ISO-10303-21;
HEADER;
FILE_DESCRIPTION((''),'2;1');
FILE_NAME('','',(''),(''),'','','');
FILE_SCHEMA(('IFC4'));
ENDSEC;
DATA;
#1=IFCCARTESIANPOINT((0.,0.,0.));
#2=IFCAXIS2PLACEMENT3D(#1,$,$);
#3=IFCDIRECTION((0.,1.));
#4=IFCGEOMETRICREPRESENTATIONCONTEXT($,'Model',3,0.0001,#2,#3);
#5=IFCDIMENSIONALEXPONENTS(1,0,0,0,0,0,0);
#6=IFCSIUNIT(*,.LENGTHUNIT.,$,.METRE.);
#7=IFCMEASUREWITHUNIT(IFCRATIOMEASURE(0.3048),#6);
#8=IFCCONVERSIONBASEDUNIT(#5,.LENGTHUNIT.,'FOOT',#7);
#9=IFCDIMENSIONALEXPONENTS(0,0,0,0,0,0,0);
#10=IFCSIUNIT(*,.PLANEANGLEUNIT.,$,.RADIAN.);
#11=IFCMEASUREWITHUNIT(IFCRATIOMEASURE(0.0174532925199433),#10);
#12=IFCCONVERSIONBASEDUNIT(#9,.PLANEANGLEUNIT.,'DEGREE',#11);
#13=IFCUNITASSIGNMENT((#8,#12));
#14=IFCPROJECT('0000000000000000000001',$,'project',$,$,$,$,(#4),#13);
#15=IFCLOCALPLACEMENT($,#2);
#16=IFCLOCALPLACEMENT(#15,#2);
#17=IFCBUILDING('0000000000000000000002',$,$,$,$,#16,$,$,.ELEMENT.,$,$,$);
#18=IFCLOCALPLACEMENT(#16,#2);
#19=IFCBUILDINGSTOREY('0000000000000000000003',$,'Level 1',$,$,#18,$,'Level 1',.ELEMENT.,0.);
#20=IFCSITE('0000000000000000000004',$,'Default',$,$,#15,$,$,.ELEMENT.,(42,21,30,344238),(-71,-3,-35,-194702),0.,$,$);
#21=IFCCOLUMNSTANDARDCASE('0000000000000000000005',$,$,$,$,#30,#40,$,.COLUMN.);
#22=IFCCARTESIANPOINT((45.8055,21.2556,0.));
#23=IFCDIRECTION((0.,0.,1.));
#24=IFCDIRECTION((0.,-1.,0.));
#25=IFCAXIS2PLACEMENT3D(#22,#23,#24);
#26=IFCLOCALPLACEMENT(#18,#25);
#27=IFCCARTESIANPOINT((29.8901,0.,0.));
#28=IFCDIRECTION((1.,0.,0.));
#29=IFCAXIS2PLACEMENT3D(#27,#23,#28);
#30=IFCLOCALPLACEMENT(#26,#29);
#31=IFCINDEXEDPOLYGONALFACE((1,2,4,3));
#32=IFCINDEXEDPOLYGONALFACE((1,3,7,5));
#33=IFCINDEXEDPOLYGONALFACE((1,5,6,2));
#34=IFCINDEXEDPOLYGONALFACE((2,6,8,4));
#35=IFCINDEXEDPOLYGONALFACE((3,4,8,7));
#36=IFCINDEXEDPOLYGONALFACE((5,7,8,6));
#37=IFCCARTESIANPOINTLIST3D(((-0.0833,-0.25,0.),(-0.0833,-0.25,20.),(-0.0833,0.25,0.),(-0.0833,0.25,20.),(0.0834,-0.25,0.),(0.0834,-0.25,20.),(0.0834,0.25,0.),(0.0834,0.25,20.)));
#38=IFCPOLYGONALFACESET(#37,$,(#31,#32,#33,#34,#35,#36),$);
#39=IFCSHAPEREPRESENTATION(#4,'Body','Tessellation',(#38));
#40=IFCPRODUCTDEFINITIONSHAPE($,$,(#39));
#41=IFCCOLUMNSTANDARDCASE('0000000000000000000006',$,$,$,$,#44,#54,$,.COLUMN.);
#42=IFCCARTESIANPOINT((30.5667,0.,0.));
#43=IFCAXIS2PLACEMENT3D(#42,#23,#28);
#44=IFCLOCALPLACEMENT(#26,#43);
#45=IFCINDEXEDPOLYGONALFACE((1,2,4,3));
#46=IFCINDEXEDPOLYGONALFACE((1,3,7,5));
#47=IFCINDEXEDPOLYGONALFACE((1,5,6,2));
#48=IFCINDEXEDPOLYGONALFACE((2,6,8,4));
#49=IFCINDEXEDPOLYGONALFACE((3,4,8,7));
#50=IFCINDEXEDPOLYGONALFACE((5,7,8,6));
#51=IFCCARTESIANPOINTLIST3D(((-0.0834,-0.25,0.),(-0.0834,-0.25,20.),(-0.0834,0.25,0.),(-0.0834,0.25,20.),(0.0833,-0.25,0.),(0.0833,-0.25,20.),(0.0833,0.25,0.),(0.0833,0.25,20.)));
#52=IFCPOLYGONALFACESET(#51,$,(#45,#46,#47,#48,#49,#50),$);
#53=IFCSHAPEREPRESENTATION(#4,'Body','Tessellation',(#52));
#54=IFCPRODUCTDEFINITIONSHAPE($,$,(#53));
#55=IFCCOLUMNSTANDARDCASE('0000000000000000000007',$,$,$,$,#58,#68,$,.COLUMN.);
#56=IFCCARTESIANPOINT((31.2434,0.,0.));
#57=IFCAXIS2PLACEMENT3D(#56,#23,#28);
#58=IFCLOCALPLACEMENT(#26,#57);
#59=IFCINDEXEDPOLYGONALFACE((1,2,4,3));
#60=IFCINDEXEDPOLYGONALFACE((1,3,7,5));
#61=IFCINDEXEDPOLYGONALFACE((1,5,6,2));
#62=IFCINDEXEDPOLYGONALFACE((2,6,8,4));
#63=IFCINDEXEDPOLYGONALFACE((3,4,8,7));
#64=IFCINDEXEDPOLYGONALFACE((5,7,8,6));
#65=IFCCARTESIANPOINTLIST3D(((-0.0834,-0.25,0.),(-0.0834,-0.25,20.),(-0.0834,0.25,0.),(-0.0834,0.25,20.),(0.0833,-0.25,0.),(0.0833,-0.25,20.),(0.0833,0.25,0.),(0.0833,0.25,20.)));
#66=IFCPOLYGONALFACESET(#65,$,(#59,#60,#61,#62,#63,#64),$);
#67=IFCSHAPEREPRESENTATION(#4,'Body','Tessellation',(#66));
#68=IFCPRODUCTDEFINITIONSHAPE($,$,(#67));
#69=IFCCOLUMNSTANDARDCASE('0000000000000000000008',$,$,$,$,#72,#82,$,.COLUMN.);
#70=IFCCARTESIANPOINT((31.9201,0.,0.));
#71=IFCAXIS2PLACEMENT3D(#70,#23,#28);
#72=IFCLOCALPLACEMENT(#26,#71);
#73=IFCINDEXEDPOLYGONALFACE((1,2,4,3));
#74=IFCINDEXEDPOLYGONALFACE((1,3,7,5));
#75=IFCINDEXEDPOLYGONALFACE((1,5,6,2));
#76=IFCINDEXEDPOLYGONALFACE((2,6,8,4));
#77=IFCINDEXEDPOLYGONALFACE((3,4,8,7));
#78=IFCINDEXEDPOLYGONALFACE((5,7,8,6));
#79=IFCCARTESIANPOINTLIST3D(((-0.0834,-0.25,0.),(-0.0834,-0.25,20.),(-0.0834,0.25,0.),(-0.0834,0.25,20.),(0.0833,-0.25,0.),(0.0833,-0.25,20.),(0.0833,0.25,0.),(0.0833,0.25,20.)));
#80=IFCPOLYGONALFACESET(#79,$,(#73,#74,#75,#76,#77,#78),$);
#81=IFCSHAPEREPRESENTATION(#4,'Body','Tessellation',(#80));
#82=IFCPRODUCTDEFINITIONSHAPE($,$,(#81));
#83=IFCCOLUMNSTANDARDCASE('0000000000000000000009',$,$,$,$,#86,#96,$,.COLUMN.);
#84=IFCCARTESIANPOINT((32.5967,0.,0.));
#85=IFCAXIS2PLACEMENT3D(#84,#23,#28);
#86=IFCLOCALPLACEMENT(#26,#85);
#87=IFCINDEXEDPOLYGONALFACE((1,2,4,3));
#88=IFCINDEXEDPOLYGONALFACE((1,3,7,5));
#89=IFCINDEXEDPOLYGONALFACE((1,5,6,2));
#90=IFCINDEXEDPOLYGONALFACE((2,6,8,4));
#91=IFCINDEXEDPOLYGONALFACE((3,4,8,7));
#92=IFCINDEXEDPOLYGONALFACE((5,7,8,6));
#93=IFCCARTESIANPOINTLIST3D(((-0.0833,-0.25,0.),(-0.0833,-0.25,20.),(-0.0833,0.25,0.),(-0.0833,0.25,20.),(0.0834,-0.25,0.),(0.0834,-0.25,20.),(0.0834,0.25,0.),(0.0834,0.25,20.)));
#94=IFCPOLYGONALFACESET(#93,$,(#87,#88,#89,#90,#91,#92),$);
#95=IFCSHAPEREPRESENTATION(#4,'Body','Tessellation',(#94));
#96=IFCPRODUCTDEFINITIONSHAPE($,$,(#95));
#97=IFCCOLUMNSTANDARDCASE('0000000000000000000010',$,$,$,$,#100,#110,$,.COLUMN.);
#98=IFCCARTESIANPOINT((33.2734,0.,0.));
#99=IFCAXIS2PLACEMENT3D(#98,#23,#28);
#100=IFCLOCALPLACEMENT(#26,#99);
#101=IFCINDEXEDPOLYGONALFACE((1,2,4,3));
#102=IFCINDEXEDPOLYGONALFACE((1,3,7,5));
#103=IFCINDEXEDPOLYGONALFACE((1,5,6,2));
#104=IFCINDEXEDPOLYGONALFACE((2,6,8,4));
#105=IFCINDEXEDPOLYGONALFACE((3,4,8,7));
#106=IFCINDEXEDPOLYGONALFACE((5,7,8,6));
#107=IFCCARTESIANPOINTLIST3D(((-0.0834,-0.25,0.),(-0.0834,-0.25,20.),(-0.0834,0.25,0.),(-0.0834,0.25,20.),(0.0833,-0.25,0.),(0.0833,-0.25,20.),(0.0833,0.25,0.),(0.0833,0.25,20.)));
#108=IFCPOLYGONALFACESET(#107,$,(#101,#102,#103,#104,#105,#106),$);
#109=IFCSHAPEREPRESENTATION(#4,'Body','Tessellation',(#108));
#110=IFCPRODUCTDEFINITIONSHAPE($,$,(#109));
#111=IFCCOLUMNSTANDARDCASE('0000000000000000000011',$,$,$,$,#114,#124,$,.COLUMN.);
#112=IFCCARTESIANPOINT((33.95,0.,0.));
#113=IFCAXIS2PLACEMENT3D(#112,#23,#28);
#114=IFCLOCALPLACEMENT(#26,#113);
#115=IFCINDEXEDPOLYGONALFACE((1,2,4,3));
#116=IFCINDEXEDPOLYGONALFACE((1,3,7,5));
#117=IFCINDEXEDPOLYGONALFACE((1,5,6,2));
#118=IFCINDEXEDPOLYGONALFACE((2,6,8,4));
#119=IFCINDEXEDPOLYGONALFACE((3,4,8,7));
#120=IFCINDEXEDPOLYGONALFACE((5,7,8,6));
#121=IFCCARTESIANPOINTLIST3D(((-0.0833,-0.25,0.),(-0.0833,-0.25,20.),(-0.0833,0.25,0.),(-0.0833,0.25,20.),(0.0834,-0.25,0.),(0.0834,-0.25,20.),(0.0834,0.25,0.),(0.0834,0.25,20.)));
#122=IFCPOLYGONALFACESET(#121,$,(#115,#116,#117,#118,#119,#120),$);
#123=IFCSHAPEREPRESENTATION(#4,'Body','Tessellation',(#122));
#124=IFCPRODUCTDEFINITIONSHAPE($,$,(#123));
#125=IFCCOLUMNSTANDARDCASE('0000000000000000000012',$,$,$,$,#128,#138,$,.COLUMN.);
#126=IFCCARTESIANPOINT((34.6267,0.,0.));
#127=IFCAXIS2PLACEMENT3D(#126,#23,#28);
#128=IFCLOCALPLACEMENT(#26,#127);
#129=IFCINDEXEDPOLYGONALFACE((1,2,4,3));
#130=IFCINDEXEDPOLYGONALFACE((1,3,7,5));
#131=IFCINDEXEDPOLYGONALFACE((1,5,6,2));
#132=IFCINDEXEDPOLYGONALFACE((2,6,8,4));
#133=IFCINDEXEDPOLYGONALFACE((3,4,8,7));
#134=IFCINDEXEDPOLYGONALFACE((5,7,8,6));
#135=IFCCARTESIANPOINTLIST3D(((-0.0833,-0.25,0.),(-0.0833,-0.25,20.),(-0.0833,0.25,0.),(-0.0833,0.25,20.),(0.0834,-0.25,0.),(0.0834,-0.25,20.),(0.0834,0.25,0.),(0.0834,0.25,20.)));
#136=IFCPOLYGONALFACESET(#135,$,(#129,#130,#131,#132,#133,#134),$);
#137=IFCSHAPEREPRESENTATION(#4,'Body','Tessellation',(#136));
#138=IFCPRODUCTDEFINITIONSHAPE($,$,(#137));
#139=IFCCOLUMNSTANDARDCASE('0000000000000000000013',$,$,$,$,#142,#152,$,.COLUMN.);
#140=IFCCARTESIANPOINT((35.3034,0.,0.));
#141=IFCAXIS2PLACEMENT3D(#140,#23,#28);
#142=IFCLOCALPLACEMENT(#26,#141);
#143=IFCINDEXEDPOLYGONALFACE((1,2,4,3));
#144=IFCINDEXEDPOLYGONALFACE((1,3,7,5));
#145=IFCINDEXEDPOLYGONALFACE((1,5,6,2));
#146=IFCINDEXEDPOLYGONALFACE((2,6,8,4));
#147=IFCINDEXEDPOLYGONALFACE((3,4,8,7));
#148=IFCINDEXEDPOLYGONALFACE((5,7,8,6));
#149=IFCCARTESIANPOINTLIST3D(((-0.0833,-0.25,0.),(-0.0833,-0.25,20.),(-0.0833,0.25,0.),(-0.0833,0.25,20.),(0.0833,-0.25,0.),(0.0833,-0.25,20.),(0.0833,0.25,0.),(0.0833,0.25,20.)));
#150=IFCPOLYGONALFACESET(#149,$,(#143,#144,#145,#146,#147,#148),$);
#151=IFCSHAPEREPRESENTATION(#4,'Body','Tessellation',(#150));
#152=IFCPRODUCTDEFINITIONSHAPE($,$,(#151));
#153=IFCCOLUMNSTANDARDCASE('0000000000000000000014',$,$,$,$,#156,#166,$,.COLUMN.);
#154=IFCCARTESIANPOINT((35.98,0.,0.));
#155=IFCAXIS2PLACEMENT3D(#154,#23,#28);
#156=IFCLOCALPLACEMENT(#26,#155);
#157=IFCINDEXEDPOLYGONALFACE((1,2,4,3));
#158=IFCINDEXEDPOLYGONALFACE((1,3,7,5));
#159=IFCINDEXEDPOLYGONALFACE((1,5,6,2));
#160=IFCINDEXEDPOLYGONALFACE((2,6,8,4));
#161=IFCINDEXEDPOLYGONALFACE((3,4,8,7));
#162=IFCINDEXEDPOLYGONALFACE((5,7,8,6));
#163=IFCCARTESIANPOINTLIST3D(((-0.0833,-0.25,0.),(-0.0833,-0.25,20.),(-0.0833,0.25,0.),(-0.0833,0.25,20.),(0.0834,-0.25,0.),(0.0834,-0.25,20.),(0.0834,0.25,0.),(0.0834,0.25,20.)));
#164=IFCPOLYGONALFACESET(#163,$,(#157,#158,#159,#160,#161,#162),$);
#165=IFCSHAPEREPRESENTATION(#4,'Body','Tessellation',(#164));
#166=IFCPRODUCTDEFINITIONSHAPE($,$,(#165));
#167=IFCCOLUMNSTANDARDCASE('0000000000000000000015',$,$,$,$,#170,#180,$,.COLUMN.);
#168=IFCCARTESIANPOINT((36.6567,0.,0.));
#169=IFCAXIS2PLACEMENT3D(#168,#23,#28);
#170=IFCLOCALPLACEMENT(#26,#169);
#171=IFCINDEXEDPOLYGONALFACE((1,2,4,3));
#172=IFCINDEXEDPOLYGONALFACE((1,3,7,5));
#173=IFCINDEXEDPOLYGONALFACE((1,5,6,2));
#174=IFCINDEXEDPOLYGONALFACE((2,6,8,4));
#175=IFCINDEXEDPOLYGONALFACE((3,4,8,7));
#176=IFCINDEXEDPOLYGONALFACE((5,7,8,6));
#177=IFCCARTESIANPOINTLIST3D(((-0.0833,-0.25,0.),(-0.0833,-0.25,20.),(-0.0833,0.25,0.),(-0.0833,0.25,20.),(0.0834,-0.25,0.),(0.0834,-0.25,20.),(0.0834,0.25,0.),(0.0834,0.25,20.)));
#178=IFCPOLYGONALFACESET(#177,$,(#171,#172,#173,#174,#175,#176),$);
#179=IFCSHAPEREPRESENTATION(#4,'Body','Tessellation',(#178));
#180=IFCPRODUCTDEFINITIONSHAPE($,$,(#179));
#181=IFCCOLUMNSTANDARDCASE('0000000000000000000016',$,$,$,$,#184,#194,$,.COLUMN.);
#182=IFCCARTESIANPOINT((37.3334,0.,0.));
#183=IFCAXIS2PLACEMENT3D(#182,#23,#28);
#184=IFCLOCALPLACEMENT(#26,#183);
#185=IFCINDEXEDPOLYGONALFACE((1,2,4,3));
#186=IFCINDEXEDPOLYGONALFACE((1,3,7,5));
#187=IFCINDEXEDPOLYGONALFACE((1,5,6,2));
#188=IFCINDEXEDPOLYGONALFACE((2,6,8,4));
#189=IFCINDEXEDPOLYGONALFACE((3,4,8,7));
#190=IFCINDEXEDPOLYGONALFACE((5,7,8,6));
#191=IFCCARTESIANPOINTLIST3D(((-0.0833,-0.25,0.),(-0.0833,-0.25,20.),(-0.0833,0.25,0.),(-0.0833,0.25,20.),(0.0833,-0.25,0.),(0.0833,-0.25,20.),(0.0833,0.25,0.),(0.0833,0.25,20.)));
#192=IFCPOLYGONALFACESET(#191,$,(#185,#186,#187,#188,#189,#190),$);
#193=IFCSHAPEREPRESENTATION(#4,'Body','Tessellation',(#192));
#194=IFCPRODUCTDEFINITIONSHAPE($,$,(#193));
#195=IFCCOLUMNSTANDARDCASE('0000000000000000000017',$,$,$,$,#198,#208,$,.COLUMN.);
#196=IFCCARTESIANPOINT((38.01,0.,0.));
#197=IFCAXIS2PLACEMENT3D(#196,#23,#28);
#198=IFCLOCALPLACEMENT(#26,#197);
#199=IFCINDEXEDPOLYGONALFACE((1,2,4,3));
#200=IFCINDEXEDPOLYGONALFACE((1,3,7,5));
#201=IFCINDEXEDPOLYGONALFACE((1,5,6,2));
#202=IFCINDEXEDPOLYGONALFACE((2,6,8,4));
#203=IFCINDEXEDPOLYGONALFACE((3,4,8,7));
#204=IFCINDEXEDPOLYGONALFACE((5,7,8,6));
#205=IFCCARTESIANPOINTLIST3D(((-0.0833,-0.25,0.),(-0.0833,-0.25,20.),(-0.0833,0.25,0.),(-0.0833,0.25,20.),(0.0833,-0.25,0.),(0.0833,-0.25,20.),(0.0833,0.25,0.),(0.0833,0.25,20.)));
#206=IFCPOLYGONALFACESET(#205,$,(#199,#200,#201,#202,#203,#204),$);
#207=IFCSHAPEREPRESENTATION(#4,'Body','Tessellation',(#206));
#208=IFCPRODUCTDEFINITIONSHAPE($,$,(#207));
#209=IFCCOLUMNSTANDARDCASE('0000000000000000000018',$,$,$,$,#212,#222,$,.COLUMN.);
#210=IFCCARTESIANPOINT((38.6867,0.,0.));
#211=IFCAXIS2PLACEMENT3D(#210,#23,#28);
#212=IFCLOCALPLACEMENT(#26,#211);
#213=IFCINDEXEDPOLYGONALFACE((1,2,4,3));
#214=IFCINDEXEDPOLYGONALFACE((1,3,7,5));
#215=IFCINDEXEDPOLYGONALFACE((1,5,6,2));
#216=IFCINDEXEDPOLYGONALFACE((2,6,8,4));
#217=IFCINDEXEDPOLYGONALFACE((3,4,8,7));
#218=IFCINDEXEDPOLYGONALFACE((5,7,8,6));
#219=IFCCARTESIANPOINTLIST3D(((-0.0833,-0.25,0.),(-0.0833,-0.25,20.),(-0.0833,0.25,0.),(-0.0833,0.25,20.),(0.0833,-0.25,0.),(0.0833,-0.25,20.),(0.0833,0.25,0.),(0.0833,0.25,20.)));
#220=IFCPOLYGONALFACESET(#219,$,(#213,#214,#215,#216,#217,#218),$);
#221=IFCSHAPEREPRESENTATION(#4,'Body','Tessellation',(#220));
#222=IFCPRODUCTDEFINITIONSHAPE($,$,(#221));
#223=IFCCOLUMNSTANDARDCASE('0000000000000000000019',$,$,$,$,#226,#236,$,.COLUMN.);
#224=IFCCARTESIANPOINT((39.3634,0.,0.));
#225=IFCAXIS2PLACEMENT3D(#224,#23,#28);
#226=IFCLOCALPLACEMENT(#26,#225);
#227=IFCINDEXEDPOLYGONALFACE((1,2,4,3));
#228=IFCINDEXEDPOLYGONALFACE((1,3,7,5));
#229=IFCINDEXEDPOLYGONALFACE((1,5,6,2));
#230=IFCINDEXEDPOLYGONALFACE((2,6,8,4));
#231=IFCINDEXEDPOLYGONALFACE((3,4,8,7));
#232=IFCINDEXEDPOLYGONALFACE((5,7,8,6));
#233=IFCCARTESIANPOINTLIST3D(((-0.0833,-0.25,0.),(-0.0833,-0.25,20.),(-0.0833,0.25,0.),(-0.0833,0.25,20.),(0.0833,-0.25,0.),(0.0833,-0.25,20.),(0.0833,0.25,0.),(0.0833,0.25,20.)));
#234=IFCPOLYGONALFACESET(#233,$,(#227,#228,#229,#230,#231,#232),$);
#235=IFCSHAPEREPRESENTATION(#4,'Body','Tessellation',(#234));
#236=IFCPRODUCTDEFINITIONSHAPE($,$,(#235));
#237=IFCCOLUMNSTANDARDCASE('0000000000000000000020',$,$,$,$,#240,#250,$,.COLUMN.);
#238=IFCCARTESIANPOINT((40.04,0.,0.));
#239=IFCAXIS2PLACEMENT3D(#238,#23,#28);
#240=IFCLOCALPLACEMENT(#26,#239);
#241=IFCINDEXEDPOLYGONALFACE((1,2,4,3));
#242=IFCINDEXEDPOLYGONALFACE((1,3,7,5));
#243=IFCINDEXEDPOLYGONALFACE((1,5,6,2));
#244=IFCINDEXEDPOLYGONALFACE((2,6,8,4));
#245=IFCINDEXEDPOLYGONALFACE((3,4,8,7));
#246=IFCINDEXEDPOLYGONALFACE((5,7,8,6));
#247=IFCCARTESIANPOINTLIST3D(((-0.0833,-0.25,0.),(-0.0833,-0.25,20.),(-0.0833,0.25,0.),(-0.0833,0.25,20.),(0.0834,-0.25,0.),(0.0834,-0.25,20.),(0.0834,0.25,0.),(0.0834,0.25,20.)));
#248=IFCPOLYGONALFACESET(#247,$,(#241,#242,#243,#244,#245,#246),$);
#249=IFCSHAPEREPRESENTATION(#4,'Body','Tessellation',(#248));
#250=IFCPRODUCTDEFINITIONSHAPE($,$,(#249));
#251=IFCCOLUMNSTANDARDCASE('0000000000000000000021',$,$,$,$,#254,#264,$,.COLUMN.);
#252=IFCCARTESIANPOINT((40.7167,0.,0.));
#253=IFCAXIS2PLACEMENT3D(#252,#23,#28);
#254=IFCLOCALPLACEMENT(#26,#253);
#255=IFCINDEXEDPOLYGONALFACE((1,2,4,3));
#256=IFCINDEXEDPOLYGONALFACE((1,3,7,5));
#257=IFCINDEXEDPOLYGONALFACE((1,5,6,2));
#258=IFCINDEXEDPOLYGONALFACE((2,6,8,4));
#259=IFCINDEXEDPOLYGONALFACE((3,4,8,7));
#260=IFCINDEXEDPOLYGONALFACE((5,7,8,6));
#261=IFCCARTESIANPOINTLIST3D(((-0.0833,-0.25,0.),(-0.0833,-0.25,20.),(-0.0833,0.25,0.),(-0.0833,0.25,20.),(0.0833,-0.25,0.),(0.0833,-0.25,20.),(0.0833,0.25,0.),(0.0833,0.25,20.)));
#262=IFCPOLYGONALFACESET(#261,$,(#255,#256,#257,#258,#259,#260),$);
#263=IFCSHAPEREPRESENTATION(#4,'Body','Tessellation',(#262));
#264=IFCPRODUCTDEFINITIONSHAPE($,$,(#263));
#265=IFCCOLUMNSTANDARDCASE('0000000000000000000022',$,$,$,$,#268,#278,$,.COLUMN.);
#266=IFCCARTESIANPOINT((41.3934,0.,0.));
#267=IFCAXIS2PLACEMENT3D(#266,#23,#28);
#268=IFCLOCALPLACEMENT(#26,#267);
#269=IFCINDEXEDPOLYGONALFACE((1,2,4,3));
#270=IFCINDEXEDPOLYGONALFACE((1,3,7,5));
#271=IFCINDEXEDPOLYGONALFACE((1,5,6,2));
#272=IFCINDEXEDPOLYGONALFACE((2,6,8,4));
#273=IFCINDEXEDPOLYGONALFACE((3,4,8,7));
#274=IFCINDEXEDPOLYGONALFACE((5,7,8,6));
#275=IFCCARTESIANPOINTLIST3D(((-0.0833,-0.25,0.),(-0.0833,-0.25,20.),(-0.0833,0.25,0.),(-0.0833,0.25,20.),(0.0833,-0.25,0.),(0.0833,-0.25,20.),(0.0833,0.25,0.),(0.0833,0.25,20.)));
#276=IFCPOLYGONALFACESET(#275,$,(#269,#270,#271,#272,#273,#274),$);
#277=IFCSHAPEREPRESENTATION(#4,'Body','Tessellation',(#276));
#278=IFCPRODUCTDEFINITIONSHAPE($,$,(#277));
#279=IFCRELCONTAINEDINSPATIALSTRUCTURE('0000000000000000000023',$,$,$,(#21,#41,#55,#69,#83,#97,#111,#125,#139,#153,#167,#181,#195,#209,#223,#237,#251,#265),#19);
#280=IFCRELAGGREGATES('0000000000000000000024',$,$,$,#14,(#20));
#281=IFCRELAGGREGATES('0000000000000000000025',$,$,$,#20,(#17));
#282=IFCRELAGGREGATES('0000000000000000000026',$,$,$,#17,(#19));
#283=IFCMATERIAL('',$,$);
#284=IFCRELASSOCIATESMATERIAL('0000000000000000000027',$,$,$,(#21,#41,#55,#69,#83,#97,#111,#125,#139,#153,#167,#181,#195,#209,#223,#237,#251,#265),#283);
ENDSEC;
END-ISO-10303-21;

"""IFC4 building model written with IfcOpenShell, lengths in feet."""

from ifc_helpers import new_model, entity, si_unit, converted_unit, direction, frame, origin, place, context, project, spatial, rectangle, extrude, material, element, save


model = new_model("IFC4")

# Units and contexts
model_context = context("Model", 3, precision=0.0001, world=origin(), true_north=direction((0.0, 1.0)))
ifc_project = project(units=[converted_unit("LENGTHUNIT", "FOOT", entity("IfcRatioMeasure", 0.3048), si_unit("LENGTHUNIT", "METRE"), dimensions=[1, 0, 0, 0, 0, 0, 0]), converted_unit("PLANEANGLEUNIT", "DEGREE", entity("IfcRatioMeasure", 0.0174532925199433), si_unit("PLANEANGLEUNIT", "RADIAN"), dimensions=[0, 0, 0, 0, 0, 0, 0])], contexts=[model_context])

# Site, building, storey
site_placement = place(None, origin())
site = spatial("IfcSite", under=ifc_project, at=site_placement, Name="Default", CompositionType="ELEMENT", RefLatitude=(42, 21, 30, 344238), RefLongitude=(-71, -3, -35, -194702), RefElevation=0.0)
building_placement = place(site_placement, origin())
building = spatial("IfcBuilding", under=site, at=building_placement, CompositionType="ELEMENT")
storey_placement = place(building_placement, origin())
storey = spatial("IfcBuildingStorey", under=building, at=storey_placement, Name="Level 1", LongName="Level 1", CompositionType="ELEMENT", Elevation=0.0)

# Columns
ifc_material_1 = material(Name="")
placement = place(storey_placement, frame((45.8055, 21.2556, 0.0), z_axis=(0.0, 0.0, 1.0), x_axis=(0.0, -1.0, 0.0)))
for number, where, z_axis, x_axis in (
    (1, (29.8901, 0.0, 0.0), (0.0, 0.0, 1.0), (1.0, 0.0, 0.0)),
    (2, (30.5667, 0.0, 0.0), (0.0, 0.0, 1.0), (1.0, 0.0, 0.0)),
    (3, (31.2434, 0.0, 0.0), (0.0, 0.0, 1.0), (1.0, 0.0, 0.0)),
    (4, (31.9201, 0.0, 0.0), (0.0, 0.0, 1.0), (1.0, 0.0, 0.0)),
    (5, (32.5967, 0.0, 0.0), (0.0, 0.0, 1.0), (1.0, 0.0, 0.0)),
    (6, (33.2734, 0.0, 0.0), (0.0, 0.0, 1.0), (1.0, 0.0, 0.0)),
    (7, (33.95, 0.0, 0.0), (0.0, 0.0, 1.0), (1.0, 0.0, 0.0)),
    (8, (34.6267, 0.0, 0.0), (0.0, 0.0, 1.0), (1.0, 0.0, 0.0)),
    (9, (35.3034, 0.0, 0.0), (0.0, 0.0, 1.0), (1.0, 0.0, 0.0)),
    (10, (35.98, 0.0, 0.0), (0.0, 0.0, 1.0), (1.0, 0.0, 0.0)),
    (11, (36.6567, 0.0, 0.0), (0.0, 0.0, 1.0), (1.0, 0.0, 0.0)),
    (12, (37.3334, 0.0, 0.0), (0.0, 0.0, 1.0), (1.0, 0.0, 0.0)),
    (13, (38.01, 0.0, 0.0), (0.0, 0.0, 1.0), (1.0, 0.0, 0.0)),
    (14, (38.6867, 0.0, 0.0), (0.0, 0.0, 1.0), (1.0, 0.0, 0.0)),
    (15, (39.3634, 0.0, 0.0), (0.0, 0.0, 1.0), (1.0, 0.0, 0.0)),
    (16, (40.04, 0.0, 0.0), (0.0, 0.0, 1.0), (1.0, 0.0, 0.0)),
    (17, (40.7167, 0.0, 0.0), (0.0, 0.0, 1.0), (1.0, 0.0, 0.0)),
    (18, (41.3934, 0.0, 0.0), (0.0, 0.0, 1.0), (1.0, 0.0, 0.0)),
):
    element("IfcColumnStandardCase", number, at=place(placement, frame(where, z_axis=z_axis, x_axis=x_axis)), inside=storey, material=ifc_material_1, PredefinedType="COLUMN", context=model_context, shape_type="SweptSolid", body=[
        extrude(rectangle(XDim=0.1667, YDim=0.5), origin(), (0.0, 0.0, 1.0), 20.0),
    ])

save(model, "model.ifc")
